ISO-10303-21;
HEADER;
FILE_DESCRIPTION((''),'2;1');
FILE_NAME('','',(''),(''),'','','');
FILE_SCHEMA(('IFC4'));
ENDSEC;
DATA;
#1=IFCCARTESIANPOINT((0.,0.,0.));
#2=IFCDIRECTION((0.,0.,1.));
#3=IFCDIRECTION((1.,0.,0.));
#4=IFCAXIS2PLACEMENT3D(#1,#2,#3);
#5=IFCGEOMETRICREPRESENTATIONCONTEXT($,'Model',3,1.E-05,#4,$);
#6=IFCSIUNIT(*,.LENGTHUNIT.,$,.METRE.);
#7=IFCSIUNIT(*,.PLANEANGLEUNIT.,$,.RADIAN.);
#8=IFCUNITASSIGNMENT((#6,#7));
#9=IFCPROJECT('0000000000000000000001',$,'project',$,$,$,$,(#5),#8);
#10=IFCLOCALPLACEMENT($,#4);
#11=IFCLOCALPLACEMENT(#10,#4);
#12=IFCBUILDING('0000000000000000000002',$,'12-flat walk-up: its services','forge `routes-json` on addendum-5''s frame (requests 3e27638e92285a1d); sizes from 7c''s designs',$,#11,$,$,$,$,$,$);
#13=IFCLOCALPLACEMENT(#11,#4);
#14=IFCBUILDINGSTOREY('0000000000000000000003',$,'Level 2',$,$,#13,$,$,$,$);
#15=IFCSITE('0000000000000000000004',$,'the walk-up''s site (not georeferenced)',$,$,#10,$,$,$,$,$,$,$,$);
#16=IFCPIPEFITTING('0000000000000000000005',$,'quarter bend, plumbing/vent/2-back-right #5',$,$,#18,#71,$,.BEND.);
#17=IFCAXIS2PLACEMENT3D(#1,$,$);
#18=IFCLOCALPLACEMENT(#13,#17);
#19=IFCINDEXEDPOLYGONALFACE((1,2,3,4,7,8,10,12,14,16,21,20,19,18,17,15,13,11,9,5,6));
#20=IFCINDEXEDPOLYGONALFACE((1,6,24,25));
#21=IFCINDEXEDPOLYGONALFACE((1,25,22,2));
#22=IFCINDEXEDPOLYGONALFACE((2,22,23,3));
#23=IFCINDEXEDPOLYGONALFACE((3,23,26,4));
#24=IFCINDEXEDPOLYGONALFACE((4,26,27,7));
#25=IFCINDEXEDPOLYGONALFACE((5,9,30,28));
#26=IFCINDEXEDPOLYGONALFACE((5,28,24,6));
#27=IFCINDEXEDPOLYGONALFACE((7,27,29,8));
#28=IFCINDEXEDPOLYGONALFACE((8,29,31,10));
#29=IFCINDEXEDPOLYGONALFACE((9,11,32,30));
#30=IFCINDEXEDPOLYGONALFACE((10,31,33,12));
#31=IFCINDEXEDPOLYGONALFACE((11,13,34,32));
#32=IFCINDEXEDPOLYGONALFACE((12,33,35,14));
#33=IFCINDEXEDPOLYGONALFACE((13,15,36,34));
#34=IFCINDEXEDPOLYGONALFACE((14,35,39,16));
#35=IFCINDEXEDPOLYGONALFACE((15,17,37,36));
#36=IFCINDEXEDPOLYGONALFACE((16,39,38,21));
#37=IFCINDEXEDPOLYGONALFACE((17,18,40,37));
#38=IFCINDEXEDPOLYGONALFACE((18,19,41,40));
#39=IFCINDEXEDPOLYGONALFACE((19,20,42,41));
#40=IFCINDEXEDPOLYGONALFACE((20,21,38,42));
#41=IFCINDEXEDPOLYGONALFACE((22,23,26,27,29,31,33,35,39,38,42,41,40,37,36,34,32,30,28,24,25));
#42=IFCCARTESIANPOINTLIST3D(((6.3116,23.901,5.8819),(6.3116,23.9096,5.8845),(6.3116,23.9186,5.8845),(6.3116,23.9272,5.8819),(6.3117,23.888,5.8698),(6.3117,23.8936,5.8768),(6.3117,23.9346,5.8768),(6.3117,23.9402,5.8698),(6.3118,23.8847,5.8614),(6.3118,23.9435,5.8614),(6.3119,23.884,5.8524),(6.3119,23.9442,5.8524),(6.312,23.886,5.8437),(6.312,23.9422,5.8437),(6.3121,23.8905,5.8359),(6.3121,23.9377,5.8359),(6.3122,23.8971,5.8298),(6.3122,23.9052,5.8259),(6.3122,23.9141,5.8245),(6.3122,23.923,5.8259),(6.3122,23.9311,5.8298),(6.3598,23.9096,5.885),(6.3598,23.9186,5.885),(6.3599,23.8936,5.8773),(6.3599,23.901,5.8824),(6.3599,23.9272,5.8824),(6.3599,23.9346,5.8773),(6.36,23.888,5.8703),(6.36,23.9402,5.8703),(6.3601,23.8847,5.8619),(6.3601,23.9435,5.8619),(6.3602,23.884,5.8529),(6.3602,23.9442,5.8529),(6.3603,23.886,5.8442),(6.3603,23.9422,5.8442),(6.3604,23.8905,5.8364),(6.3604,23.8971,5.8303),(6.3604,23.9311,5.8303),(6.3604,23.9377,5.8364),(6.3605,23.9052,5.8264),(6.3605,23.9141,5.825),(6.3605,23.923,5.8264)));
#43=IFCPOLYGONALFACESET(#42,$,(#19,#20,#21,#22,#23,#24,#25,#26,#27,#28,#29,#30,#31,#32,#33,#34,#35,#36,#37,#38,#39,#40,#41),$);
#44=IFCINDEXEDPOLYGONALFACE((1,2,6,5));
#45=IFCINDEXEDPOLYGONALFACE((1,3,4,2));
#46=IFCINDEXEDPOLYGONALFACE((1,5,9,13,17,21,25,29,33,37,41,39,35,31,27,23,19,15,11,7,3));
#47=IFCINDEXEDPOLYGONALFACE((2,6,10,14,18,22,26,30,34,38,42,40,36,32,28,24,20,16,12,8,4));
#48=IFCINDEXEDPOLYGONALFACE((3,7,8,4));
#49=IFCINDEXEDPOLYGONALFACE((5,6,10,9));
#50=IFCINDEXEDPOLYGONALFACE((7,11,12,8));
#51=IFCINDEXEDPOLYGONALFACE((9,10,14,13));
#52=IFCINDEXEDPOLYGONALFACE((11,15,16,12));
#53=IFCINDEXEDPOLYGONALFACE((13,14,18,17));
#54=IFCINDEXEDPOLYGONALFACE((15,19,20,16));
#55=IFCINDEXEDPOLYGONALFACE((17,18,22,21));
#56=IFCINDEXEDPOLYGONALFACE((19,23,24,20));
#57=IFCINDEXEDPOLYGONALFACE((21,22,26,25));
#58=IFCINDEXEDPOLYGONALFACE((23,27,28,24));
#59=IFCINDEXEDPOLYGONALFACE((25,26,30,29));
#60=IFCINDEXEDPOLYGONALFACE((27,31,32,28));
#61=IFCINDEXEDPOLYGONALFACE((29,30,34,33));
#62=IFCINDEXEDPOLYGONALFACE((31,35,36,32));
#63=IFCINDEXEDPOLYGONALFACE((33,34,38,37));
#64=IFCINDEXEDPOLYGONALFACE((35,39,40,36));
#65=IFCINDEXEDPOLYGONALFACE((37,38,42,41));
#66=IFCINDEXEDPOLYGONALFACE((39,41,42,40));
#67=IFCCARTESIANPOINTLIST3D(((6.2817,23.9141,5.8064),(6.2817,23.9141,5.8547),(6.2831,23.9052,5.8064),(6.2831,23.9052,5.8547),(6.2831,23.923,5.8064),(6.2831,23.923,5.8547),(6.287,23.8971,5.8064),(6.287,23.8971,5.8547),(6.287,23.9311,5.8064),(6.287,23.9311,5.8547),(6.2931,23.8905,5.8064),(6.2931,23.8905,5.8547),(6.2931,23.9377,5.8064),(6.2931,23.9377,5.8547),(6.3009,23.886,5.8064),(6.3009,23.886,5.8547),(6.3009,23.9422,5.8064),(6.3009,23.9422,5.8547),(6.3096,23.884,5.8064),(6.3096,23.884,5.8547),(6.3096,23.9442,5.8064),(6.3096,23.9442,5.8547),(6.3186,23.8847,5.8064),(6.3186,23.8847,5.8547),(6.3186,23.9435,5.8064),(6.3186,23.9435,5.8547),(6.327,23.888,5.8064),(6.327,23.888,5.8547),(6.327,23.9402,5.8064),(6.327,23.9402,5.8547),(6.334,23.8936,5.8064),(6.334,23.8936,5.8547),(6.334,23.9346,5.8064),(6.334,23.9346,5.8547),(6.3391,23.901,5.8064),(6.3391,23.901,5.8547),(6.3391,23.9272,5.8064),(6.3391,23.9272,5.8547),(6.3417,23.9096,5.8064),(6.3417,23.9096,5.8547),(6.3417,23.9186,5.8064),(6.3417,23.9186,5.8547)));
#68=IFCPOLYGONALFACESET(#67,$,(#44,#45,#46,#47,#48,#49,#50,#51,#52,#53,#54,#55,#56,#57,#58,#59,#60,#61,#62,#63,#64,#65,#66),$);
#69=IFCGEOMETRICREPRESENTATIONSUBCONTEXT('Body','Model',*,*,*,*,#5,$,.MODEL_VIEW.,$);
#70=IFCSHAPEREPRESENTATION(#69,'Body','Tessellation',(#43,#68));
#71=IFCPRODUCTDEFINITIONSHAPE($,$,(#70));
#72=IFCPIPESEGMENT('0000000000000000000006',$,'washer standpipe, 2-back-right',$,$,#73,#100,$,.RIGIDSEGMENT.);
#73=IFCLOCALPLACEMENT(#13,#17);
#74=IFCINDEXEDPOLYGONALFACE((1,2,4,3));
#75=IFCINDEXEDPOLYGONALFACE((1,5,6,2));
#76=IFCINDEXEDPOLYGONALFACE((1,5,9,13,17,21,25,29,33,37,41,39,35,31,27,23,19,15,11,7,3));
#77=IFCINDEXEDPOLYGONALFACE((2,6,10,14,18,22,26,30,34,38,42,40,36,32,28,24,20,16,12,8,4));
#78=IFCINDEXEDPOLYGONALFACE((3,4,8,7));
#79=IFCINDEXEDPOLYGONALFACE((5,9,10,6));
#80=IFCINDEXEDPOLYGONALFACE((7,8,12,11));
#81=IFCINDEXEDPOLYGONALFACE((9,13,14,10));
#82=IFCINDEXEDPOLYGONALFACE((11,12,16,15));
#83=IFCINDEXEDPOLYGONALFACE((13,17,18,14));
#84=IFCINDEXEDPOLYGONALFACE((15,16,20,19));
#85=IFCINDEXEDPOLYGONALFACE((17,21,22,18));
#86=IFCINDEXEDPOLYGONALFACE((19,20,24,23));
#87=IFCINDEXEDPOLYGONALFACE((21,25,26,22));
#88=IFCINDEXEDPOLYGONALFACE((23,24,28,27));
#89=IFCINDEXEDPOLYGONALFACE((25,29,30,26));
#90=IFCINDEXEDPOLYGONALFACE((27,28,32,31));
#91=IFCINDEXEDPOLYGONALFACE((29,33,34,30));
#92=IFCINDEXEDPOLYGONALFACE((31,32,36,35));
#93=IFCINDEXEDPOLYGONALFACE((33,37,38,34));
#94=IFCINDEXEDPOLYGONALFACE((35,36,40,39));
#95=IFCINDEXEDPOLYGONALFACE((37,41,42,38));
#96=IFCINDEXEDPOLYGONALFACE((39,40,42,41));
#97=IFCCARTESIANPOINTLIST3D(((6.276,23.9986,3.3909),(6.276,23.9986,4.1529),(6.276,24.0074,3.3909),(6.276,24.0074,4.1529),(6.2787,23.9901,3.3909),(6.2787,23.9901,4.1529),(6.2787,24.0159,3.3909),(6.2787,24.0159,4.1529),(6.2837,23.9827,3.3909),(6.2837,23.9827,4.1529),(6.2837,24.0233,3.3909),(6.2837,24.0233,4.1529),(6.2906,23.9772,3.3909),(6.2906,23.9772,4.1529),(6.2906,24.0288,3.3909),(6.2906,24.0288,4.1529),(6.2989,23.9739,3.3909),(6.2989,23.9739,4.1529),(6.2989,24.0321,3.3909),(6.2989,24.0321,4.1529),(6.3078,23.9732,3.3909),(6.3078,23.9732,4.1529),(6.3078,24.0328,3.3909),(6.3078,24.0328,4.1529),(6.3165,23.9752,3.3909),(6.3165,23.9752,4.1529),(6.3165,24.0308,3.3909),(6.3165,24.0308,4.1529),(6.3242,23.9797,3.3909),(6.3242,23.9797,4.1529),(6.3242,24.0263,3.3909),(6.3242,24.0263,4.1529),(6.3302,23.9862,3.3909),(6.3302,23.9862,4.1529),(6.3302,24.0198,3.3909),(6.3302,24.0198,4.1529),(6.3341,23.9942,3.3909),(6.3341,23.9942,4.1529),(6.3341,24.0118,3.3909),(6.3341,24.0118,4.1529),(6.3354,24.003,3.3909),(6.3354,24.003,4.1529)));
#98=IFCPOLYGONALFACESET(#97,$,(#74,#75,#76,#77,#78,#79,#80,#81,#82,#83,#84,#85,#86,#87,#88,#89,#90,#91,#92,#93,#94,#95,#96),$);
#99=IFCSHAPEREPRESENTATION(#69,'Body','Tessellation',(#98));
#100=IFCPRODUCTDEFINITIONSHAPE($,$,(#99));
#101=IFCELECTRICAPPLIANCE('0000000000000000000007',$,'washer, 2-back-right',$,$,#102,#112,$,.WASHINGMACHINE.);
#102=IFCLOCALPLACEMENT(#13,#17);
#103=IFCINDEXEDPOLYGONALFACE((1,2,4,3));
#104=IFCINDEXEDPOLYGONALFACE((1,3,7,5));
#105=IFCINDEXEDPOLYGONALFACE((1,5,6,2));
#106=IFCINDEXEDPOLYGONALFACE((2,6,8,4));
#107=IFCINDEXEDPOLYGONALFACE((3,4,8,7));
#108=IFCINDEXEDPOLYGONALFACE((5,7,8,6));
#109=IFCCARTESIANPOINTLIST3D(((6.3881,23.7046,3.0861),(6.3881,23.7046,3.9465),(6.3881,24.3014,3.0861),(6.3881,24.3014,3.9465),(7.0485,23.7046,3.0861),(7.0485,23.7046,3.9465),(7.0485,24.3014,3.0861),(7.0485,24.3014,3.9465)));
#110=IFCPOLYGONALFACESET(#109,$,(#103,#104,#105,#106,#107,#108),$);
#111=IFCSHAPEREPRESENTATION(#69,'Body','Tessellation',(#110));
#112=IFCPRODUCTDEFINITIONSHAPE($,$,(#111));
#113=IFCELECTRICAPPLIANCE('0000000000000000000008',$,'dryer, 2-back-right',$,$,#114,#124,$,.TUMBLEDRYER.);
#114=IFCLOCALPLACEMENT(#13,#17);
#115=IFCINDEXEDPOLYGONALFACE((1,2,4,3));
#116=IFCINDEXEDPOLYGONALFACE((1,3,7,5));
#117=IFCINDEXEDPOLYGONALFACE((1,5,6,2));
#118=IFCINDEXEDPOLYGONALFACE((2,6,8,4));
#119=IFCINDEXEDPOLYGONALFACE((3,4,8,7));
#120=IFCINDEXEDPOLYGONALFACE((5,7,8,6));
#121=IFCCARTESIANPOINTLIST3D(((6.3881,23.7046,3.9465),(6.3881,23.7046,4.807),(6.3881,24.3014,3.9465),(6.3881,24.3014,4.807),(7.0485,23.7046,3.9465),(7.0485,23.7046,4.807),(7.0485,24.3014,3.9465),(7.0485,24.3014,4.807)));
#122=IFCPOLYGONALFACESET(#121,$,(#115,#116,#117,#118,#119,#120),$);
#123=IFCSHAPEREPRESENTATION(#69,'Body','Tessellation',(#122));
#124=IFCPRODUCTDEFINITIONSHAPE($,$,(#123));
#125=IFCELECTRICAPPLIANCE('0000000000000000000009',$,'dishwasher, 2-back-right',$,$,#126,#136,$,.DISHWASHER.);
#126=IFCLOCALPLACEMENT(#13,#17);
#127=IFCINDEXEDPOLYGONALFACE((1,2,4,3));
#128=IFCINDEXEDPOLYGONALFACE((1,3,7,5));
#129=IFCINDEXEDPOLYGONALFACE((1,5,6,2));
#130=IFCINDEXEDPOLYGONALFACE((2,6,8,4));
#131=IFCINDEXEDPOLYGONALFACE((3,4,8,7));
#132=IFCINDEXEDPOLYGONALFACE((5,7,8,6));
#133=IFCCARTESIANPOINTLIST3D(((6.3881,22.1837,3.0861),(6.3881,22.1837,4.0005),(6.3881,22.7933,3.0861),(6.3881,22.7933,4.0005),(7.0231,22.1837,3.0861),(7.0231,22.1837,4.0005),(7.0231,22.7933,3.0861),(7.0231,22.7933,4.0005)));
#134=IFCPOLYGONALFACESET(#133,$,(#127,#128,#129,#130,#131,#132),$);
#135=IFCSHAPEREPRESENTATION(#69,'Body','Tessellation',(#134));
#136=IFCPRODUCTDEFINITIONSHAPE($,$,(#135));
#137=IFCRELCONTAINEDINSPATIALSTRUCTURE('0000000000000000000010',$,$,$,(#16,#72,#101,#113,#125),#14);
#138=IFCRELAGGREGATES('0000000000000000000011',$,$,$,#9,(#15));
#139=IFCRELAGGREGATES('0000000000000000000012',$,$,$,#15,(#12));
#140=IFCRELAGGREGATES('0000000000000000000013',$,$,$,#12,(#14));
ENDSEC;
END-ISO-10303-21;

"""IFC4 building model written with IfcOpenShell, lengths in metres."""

from ifc_helpers import new_model, entity, si_unit, frame, frame_2d, origin, origin_with_axes, place, context, subcontext, project, spatial, rectangle, extrude, element, save


model = new_model("IFC4")

# Units and contexts
model_context = context("Model", 3, precision=1e-05, world=origin_with_axes())
body_context = subcontext(model_context, "Body", "Model", "MODEL_VIEW")
ifc_project = project(units=[si_unit("LENGTHUNIT", "METRE"), si_unit("PLANEANGLEUNIT", "RADIAN")], contexts=[model_context])

# Site, building, storey
site_placement = place(None, origin_with_axes())
site = spatial("IfcSite", under=ifc_project, at=site_placement, Name="the walk-up's site (not georeferenced)")
building_placement = place(site_placement, origin_with_axes())
building = spatial("IfcBuilding", under=site, at=building_placement, Name="12-flat walk-up: its services", Description="forge `routes-json` on addendum-5's frame (requests 3e27638e92285a1d); sizes from 7c's designs")
storey_placement = place(building_placement, origin_with_axes())
storey = spatial("IfcBuildingStorey", under=building, at=storey_placement, Name="Level 2")

# Pipe fitting
pipe_fitting_1_placement = place(storey_placement, frame((6.3602, 23.9141, 5.8552), z_axis=(0.0, 0.0, 1.0), x_axis=(1.0, 0.0, 0.0)))
element("IfcPipeFitting", 1, at=pipe_fitting_1_placement, inside=storey, Name="quarter bend, plumbing/vent/2-back-right #5", PredefinedType="BEND", context=body_context, shape_type="AdvancedSweptSolid", body=[
    entity("IfcSweptDiskSolid", entity("IfcPolyline", [entity("IfcCartesianPoint", [0.0, 0.0, 0.0]), entity("IfcCartesianPoint", [-0.0483, 0.0, -0.0005])]), 0.0302),
    entity("IfcSweptDiskSolid", entity("IfcPolyline", [entity("IfcCartesianPoint", [-0.0483, 0.0, -0.0005]), entity("IfcCartesianPoint", [-0.0483, 0.0, -0.0488])]), 0.0302),
])

# Pipe segment
pipe_segment_1_placement = place(storey_placement, frame((6.3056, 24.003, 3.3909), z_axis=(0.0, 0.0, 1.0), x_axis=(1.0, 0.0, 0.0)))
element("IfcPipeSegment", 2, at=pipe_segment_1_placement, inside=storey, Name="washer standpipe, 2-back-right", PredefinedType="RIGIDSEGMENT", context=body_context, shape_type="AdvancedSweptSolid", body=[
    entity("IfcSweptDiskSolid", entity("IfcPolyline", [entity("IfcCartesianPoint", [0.0, 0.0, 0.0]), entity("IfcCartesianPoint", [0.0, 0.0, 0.762])]), 0.0298),
])

# Electric appliances
electric_appliance_1_placement = place(storey_placement, frame((6.3881, 23.7046, 3.0861), z_axis=(0.0, 0.0, 1.0), x_axis=(1.0, 0.0, 0.0)))
element("IfcElectricAppliance", 3, at=electric_appliance_1_placement, inside=storey, Name="washer, 2-back-right", PredefinedType="WASHINGMACHINE", context=body_context, shape_type="SweptSolid", body=[
    extrude(rectangle(XDim=0.6604, YDim=0.5969, at=frame_2d((0.3302, 0.2984))), origin(), (0.0, 0.0, 1.0), 0.8604),
])
electric_appliance_2_placement = place(storey_placement, frame((6.3881, 23.7046, 3.9465), z_axis=(0.0, 0.0, 1.0), x_axis=(1.0, 0.0, 0.0)))
element("IfcElectricAppliance", 4, at=electric_appliance_2_placement, inside=storey, Name="dryer, 2-back-right", PredefinedType="TUMBLEDRYER", context=body_context, shape_type="SweptSolid", body=[
    extrude(rectangle(XDim=0.6604, YDim=0.5969, at=frame_2d((0.3302, 0.2984))), origin(), (0.0, 0.0, 1.0), 0.8604),
])
electric_appliance_3_placement = place(storey_placement, frame((6.3881, 22.1837, 3.0861), z_axis=(0.0, 0.0, 1.0), x_axis=(1.0, 0.0, 0.0)))
element("IfcElectricAppliance", 5, at=electric_appliance_3_placement, inside=storey, Name="dishwasher, 2-back-right", PredefinedType="DISHWASHER", context=body_context, shape_type="SweptSolid", body=[
    extrude(rectangle(XDim=0.635, YDim=0.6096, at=frame_2d((0.3175, 0.3048))), origin(), (0.0, 0.0, 1.0), 0.9144),
])

save(model, "model.ifc")
